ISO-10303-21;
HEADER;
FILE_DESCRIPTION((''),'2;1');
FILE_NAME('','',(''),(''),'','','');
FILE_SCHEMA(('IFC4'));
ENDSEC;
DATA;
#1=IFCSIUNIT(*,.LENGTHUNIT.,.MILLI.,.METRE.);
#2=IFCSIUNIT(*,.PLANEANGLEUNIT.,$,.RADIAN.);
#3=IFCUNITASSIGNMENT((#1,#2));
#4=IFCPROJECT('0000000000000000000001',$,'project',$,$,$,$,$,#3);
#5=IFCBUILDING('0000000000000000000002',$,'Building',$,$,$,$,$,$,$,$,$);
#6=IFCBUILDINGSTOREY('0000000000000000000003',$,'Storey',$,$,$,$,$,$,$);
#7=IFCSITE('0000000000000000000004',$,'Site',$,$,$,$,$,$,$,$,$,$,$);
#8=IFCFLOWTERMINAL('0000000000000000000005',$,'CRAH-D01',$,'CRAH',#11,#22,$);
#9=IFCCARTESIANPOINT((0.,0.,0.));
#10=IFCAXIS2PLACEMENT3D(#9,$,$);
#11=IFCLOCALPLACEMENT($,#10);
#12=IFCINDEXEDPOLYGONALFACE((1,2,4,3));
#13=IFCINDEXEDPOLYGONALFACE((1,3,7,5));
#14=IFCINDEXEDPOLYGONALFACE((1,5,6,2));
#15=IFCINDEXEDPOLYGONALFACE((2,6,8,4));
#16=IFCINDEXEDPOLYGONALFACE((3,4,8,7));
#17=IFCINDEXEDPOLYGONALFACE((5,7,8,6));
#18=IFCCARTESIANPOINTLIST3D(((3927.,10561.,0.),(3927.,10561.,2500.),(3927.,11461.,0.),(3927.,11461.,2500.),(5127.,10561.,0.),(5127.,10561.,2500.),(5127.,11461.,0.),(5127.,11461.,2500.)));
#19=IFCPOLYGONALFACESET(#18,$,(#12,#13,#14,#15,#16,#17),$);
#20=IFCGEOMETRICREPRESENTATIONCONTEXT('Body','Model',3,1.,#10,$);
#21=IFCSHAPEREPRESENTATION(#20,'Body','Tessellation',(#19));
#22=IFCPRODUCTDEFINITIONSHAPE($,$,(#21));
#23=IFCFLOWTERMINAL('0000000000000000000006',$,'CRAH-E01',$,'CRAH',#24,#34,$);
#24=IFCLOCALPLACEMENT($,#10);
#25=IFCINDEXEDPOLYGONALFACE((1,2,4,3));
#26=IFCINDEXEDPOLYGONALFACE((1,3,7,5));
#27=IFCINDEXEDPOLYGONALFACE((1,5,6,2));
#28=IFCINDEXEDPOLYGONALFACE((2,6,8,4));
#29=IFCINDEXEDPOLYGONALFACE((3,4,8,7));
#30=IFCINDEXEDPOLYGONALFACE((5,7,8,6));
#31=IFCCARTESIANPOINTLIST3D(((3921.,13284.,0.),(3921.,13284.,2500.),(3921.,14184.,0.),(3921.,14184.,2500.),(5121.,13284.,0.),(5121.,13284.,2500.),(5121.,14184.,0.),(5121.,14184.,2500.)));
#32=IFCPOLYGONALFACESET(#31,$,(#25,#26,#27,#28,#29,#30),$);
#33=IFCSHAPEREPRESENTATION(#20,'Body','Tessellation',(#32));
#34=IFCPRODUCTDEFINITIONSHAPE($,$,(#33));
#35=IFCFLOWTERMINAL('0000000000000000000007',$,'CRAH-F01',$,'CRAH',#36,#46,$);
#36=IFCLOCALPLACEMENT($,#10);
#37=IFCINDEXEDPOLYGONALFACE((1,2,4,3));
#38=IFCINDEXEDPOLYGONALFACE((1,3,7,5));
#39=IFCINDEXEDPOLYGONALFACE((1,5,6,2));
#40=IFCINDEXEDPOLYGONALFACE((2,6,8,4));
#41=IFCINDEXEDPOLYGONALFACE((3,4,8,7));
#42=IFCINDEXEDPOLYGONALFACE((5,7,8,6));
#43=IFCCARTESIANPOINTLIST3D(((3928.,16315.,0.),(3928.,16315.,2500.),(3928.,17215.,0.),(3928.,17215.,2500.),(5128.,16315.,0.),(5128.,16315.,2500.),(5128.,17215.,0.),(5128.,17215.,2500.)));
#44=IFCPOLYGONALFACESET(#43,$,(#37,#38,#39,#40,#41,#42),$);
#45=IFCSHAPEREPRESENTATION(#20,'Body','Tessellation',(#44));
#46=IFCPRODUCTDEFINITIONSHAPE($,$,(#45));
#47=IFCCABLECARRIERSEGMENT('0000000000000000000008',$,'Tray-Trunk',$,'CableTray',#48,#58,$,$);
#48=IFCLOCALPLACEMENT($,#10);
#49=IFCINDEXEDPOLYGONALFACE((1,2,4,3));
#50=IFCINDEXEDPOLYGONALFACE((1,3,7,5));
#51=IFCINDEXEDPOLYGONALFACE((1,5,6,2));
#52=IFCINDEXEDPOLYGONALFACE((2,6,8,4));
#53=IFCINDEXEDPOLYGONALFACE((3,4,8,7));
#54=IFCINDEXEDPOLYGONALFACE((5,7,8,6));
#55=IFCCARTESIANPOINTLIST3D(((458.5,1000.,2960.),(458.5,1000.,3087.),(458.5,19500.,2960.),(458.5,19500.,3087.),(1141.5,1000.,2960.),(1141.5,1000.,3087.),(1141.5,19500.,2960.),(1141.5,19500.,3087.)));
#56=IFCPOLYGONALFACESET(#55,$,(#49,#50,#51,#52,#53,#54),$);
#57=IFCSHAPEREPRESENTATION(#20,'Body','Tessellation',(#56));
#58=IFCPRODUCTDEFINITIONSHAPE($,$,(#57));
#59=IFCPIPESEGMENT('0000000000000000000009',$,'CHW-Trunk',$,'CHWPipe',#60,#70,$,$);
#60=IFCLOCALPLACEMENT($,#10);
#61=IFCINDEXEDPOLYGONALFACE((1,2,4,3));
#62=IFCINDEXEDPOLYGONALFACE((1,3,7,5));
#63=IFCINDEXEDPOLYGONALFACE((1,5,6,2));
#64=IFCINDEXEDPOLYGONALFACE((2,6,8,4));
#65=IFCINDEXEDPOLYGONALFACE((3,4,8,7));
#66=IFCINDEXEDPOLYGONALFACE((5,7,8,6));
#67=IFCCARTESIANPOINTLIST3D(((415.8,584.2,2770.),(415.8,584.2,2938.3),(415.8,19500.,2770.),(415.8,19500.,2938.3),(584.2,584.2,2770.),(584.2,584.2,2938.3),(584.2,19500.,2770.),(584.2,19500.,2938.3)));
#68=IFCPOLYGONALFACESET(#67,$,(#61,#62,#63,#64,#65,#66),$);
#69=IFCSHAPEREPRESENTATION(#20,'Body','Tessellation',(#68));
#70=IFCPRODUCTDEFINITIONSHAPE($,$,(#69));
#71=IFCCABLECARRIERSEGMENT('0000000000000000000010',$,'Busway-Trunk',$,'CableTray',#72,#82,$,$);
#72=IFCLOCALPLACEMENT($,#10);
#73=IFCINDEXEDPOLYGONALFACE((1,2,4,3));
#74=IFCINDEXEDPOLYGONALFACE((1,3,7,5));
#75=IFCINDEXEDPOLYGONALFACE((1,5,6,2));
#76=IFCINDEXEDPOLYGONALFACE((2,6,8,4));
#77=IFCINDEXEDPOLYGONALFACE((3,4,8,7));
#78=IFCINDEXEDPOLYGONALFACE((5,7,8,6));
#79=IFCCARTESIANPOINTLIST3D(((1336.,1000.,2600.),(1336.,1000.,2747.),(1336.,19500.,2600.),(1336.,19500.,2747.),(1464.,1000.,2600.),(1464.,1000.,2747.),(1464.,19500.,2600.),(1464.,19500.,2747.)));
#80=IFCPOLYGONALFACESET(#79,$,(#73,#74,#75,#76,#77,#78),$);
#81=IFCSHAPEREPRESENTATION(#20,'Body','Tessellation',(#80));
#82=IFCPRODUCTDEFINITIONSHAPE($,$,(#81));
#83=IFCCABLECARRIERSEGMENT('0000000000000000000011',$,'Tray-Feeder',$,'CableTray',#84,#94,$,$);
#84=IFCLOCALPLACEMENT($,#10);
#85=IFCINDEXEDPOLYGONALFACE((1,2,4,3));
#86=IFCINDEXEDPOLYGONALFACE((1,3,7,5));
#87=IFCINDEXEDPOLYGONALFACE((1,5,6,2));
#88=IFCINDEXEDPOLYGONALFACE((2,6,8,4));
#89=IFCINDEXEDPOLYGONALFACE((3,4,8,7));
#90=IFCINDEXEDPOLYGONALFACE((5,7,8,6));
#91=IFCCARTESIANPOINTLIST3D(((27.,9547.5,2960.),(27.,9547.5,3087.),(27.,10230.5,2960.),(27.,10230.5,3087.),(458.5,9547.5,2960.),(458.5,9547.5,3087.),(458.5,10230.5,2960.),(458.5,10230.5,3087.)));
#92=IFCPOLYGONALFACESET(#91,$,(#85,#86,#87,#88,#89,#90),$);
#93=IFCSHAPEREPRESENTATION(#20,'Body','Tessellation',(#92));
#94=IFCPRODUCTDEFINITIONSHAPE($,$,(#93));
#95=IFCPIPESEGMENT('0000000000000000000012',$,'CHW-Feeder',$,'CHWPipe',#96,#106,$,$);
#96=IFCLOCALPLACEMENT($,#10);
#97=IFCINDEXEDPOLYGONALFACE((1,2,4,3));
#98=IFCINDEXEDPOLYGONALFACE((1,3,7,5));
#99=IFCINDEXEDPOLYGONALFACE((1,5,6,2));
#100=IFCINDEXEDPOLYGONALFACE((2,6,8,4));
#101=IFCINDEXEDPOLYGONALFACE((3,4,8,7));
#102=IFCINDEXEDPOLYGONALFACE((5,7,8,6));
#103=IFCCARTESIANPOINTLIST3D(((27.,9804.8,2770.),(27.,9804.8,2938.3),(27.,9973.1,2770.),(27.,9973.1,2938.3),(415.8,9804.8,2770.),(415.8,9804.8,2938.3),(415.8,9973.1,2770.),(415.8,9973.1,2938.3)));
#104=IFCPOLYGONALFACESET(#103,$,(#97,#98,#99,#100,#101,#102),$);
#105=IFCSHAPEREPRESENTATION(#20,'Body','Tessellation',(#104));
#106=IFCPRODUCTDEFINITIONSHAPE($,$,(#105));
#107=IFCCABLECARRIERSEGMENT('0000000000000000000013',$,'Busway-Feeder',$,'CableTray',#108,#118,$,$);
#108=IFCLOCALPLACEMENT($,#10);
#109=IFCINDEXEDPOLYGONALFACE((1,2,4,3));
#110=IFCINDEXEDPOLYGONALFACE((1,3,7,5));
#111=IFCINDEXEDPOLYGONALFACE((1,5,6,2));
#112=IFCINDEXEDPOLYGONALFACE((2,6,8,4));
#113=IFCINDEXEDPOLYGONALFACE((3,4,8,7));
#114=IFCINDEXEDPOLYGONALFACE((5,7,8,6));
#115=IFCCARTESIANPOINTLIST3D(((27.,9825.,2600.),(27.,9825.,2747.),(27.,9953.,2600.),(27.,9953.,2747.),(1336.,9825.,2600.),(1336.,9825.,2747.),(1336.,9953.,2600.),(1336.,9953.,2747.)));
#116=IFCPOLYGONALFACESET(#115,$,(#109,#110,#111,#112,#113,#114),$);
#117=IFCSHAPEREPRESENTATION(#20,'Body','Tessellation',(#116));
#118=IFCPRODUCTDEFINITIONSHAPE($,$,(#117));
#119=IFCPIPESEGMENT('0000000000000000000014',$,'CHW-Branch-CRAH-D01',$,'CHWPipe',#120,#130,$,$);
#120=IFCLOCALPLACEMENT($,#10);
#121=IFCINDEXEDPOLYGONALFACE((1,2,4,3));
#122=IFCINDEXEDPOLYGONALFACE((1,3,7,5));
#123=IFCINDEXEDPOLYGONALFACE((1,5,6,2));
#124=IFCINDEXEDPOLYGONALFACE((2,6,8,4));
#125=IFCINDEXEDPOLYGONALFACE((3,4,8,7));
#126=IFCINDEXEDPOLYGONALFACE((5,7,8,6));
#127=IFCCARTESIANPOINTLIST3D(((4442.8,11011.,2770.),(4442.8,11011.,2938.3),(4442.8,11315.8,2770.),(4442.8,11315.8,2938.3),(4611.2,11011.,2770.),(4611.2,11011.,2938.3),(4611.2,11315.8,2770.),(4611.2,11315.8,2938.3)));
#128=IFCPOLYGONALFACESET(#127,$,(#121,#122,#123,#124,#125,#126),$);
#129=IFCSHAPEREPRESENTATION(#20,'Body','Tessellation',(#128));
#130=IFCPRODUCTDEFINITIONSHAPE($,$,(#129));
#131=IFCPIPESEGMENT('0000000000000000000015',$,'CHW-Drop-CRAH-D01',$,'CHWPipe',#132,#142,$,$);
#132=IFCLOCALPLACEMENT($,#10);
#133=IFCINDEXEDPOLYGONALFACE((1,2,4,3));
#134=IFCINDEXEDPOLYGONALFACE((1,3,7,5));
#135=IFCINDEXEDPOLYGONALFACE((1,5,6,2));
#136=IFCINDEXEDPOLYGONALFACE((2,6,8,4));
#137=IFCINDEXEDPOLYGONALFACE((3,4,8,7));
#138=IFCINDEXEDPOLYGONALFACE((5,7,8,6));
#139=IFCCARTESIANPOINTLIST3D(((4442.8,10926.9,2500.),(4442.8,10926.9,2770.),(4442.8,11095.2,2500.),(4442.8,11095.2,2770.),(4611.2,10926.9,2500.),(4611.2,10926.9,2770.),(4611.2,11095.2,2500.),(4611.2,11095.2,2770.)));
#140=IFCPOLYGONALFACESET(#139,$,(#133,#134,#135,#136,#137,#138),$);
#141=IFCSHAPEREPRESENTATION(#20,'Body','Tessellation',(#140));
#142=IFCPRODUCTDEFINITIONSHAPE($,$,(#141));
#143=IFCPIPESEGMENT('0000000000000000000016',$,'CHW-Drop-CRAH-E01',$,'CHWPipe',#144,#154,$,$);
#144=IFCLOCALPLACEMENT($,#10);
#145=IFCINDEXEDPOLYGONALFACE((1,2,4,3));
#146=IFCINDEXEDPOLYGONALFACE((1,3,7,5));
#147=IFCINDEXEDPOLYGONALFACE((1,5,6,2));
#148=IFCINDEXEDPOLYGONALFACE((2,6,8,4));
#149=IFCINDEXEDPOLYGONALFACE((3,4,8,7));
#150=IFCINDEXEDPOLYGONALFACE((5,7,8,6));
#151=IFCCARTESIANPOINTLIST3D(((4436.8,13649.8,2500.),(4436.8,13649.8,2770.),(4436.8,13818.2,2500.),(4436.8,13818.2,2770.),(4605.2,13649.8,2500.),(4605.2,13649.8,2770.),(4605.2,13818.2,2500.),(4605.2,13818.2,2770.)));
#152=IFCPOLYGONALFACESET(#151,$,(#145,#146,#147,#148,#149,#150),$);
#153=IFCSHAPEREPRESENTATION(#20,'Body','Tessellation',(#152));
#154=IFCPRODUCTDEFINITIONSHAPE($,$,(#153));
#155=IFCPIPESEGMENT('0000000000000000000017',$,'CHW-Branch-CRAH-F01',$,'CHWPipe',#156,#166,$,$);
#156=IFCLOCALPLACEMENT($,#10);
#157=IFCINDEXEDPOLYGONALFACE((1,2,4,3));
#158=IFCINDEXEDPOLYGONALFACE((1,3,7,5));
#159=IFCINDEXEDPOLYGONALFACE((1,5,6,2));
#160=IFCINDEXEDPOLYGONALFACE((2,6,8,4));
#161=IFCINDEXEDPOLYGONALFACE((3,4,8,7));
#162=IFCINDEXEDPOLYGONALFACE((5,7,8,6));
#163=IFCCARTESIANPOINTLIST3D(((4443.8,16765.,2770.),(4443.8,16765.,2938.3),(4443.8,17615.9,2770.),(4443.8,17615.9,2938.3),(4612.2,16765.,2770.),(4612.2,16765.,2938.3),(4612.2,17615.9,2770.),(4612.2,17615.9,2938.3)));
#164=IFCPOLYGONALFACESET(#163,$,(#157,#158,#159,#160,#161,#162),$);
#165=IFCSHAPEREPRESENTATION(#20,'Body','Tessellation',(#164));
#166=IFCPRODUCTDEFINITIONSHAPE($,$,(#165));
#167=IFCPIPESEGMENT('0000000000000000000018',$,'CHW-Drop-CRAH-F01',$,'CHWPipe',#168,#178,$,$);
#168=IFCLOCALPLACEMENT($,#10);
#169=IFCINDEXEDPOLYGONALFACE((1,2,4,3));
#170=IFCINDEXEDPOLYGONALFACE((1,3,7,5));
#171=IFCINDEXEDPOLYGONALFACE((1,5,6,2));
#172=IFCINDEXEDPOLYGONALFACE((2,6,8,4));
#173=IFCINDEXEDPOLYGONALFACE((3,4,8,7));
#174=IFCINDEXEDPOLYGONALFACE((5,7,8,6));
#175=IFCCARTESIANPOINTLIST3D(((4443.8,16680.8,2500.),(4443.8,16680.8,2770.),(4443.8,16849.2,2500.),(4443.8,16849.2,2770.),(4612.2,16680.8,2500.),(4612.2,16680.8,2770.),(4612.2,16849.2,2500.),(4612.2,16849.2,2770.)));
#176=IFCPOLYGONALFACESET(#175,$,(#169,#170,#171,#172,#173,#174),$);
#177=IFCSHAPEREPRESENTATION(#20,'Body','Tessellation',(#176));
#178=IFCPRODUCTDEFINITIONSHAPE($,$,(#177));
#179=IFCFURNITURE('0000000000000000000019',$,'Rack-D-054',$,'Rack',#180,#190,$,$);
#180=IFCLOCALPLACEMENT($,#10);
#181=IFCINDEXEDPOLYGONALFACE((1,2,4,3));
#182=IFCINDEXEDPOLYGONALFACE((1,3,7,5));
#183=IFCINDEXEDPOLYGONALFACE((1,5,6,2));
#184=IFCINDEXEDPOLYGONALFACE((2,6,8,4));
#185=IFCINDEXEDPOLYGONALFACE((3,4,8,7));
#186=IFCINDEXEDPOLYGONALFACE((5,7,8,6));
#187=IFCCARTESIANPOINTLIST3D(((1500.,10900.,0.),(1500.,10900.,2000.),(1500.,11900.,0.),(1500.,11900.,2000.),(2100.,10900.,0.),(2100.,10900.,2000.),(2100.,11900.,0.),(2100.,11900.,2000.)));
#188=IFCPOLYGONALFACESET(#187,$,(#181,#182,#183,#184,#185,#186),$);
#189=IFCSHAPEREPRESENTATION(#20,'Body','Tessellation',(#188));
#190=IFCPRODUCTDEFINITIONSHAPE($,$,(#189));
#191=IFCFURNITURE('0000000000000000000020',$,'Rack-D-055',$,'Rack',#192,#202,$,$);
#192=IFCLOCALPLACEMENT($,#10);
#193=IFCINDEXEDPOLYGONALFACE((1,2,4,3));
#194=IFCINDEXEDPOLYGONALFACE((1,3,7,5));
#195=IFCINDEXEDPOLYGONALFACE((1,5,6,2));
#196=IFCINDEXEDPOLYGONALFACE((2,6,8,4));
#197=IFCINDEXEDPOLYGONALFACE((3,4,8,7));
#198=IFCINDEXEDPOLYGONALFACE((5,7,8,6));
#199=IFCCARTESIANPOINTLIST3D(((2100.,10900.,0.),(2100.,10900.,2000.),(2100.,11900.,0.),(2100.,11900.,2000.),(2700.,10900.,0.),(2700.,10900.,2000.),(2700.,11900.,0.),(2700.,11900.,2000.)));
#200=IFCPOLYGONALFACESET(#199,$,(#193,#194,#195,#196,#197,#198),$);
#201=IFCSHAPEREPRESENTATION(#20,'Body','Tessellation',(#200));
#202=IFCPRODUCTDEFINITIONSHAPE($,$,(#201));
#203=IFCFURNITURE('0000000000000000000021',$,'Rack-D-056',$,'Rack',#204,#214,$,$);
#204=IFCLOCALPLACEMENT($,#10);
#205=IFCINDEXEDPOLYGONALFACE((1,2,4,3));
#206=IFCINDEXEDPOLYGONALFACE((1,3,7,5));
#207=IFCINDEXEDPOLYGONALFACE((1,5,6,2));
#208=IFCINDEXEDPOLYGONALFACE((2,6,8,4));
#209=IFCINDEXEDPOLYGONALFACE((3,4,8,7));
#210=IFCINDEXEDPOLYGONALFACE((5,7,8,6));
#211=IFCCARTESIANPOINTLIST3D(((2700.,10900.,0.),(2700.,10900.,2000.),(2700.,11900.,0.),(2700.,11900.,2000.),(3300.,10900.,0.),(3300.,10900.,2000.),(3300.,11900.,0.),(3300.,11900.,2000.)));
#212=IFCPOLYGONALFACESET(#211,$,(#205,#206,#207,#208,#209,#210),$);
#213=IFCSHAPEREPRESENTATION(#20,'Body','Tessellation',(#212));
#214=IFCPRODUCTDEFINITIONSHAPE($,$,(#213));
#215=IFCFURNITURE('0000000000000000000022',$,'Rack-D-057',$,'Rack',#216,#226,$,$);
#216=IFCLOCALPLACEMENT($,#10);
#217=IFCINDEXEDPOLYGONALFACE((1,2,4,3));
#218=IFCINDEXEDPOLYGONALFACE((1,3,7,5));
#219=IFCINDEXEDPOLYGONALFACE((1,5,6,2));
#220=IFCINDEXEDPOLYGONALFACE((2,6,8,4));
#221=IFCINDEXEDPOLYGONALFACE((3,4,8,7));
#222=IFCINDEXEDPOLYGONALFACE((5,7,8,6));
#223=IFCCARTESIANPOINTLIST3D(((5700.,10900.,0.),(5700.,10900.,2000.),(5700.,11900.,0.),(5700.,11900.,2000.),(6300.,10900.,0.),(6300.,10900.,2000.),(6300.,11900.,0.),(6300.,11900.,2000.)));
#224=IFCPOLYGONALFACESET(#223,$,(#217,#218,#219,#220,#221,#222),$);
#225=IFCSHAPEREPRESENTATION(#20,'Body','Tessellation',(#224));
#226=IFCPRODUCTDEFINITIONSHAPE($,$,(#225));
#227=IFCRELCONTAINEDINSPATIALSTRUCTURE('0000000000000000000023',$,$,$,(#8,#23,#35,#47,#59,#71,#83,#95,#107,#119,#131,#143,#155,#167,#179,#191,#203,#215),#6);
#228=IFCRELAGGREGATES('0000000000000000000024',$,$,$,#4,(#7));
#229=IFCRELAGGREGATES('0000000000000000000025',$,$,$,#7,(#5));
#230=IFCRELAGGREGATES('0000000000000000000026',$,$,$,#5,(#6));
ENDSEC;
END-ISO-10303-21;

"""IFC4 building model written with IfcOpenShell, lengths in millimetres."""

from ifc_helpers import new_model, si_unit, frame, origin, place, context, project, spatial, rectangle, extrude, element, save


model = new_model("IFC4")

# Units and contexts
model_context = context("Model", 3, precision=1.0, world=origin(), identifier="Body")
ifc_project = project(units=[si_unit("LENGTHUNIT", "METRE", prefix="MILLI"), si_unit("PLANEANGLEUNIT", "RADIAN")])

# Site, building, storey
site = spatial("IfcSite", under=ifc_project, Name="Site")
building = spatial("IfcBuilding", under=site, Name="Building")
storey = spatial("IfcBuildingStorey", under=building, Name="Storey")

# Flow terminals
for number, where, z_axis, x_axis, name in (
    (1, (4527.0, 11011.0, 0.0), (0.0, 0.0, 1.0), (1.0, 0.0, 0.0), "CRAH-D01"),
    (2, (4521.0, 13734.0, 0.0), (0.0, 0.0, 1.0), (1.0, 0.0, 0.0), "CRAH-E01"),
    (3, (4528.0, 16765.0, 0.0), (0.0, 0.0, 1.0), (1.0, 0.0, 0.0), "CRAH-F01"),
):
    element("IfcFlowTerminal", number, at=place(None, frame(where, z_axis=z_axis, x_axis=x_axis)), inside=storey, Name=name, ObjectType="CRAH", context=model_context, shape_type="SweptSolid", body=[
        extrude(rectangle(XDim=1200.0, YDim=900.0), origin(), (0.0, 0.0, 1.0), 2500.0),
    ])

# Cable carrier segment
cable_carrier_segment_1_placement = place(None, frame((800.0, 10250.0, 2960.0), z_axis=(0.0, 0.0, 1.0), x_axis=(1.0, 0.0, 0.0)))
element("IfcCableCarrierSegment", 4, at=cable_carrier_segment_1_placement, inside=storey, Name="Tray-Trunk", ObjectType="CableTray", context=model_context, shape_type="SweptSolid", body=[
    extrude(rectangle(XDim=683.0, YDim=18500.0), origin(), (0.0, 0.0, 1.0), 127.0),
])

# Pipe segment
pipe_segment_1_placement = place(None, frame((500.0, 10042.1, 2770.0), z_axis=(0.0, 0.0, 1.0), x_axis=(1.0, 0.0, 0.0)))
element("IfcPipeSegment", 5, at=pipe_segment_1_placement, inside=storey, Name="CHW-Trunk", ObjectType="CHWPipe", context=model_context, shape_type="SweptSolid", body=[
    extrude(rectangle(XDim=168.3, YDim=18915.8), origin(), (0.0, 0.0, 1.0), 168.3),
])

# Cable carrier segments
cable_carrier_segment_2_placement = place(None, frame((1400.0, 10250.0, 2600.0), z_axis=(0.0, 0.0, 1.0), x_axis=(1.0, 0.0, 0.0)))
element("IfcCableCarrierSegment", 6, at=cable_carrier_segment_2_placement, inside=storey, Name="Busway-Trunk", ObjectType="CableTray", context=model_context, shape_type="SweptSolid", body=[
    extrude(rectangle(XDim=128.0, YDim=18500.0), origin(), (0.0, 0.0, 1.0), 147.0),
])
cable_carrier_segment_3_placement = place(None, frame((242.8, 9889.0, 2960.0), z_axis=(0.0, 0.0, 1.0), x_axis=(1.0, 0.0, 0.0)))
element("IfcCableCarrierSegment", 7, at=cable_carrier_segment_3_placement, inside=storey, Name="Tray-Feeder", ObjectType="CableTray", context=model_context, shape_type="SweptSolid", body=[
    extrude(rectangle(XDim=431.5, YDim=683.0), origin(), (0.0, 0.0, 1.0), 127.0),
])

# Pipe segment
pipe_segment_2_placement = place(None, frame((221.4, 9889.0, 2770.0), z_axis=(0.0, 0.0, 1.0), x_axis=(1.0, 0.0, 0.0)))
element("IfcPipeSegment", 8, at=pipe_segment_2_placement, inside=storey, Name="CHW-Feeder", ObjectType="CHWPipe", context=model_context, shape_type="SweptSolid", body=[
    extrude(rectangle(XDim=388.9, YDim=168.3), origin(), (0.0, 0.0, 1.0), 168.3),
])

# Cable carrier segment
cable_carrier_segment_4_placement = place(None, frame((681.5, 9889.0, 2600.0), z_axis=(0.0, 0.0, 1.0), x_axis=(1.0, 0.0, 0.0)))
element("IfcCableCarrierSegment", 9, at=cable_carrier_segment_4_placement, inside=storey, Name="Busway-Feeder", ObjectType="CableTray", context=model_context, shape_type="SweptSolid", body=[
    extrude(rectangle(XDim=1309.0, YDim=128.0), origin(), (0.0, 0.0, 1.0), 147.0),
])

# Pipe segments
pipe_segment_3_placement = place(None, frame((4527.0, 11163.4, 2770.0), z_axis=(0.0, 0.0, 1.0), x_axis=(1.0, 0.0, 0.0)))
element("IfcPipeSegment", 10, at=pipe_segment_3_placement, inside=storey, Name="CHW-Branch-CRAH-D01", ObjectType="CHWPipe", context=model_context, shape_type="SweptSolid", body=[
    extrude(rectangle(XDim=168.3, YDim=304.9), origin(), (0.0, 0.0, 1.0), 168.3),
])
for number, where, z_axis, x_axis, name in (
    (11, (4527.0, 11011.0, 2500.0), (0.0, 0.0, 1.0), (1.0, 0.0, 0.0), "CHW-Drop-CRAH-D01"),
    (12, (4521.0, 13734.0, 2500.0), (0.0, 0.0, 1.0), (1.0, 0.0, 0.0), "CHW-Drop-CRAH-E01"),
):
    element("IfcPipeSegment", number, at=place(None, frame(where, z_axis=z_axis, x_axis=x_axis)), inside=storey, Name=name, ObjectType="CHWPipe", context=model_context, shape_type="SweptSolid", body=[
        extrude(rectangle(XDim=168.3, YDim=168.3), origin(), (0.0, 0.0, 1.0), 270.0),
    ])
pipe_segment_4_placement = place(None, frame((4528.0, 17190.4, 2770.0), z_axis=(0.0, 0.0, 1.0), x_axis=(1.0, 0.0, 0.0)))
element("IfcPipeSegment", 13, at=pipe_segment_4_placement, inside=storey, Name="CHW-Branch-CRAH-F01", ObjectType="CHWPipe", context=model_context, shape_type="SweptSolid", body=[
    extrude(rectangle(XDim=168.3, YDim=850.8), origin(), (0.0, 0.0, 1.0), 168.3),
])
pipe_segment_5_placement = place(None, frame((4528.0, 16765.0, 2500.0), z_axis=(0.0, 0.0, 1.0), x_axis=(1.0, 0.0, 0.0)))
element("IfcPipeSegment", 14, at=pipe_segment_5_placement, inside=storey, Name="CHW-Drop-CRAH-F01", ObjectType="CHWPipe", context=model_context, shape_type="SweptSolid", body=[
    extrude(rectangle(XDim=168.3, YDim=168.3), origin(), (0.0, 0.0, 1.0), 270.0),
])

# Furniture
for number, where, z_axis, x_axis, name in (
    (15, (1800.0, 11400.0, 0.0), (0.0, 0.0, 1.0), (1.0, 0.0, 0.0), "Rack-D-054"),
    (16, (2400.0, 11400.0, 0.0), (0.0, 0.0, 1.0), (1.0, 0.0, 0.0), "Rack-D-055"),
    (17, (3000.0, 11400.0, 0.0), (0.0, 0.0, 1.0), (1.0, 0.0, 0.0), "Rack-D-056"),
    (18, (6000.0, 11400.0, 0.0), (0.0, 0.0, 1.0), (1.0, 0.0, 0.0), "Rack-D-057"),
):
    element("IfcFurniture", number, at=place(None, frame(where, z_axis=z_axis, x_axis=x_axis)), inside=storey, Name=name, ObjectType="Rack", context=model_context, shape_type="SweptSolid", body=[
        extrude(rectangle(XDim=600.0, YDim=1000.0), origin(), (0.0, 0.0, 1.0), 2000.0),
    ])

save(model, "model.ifc")
